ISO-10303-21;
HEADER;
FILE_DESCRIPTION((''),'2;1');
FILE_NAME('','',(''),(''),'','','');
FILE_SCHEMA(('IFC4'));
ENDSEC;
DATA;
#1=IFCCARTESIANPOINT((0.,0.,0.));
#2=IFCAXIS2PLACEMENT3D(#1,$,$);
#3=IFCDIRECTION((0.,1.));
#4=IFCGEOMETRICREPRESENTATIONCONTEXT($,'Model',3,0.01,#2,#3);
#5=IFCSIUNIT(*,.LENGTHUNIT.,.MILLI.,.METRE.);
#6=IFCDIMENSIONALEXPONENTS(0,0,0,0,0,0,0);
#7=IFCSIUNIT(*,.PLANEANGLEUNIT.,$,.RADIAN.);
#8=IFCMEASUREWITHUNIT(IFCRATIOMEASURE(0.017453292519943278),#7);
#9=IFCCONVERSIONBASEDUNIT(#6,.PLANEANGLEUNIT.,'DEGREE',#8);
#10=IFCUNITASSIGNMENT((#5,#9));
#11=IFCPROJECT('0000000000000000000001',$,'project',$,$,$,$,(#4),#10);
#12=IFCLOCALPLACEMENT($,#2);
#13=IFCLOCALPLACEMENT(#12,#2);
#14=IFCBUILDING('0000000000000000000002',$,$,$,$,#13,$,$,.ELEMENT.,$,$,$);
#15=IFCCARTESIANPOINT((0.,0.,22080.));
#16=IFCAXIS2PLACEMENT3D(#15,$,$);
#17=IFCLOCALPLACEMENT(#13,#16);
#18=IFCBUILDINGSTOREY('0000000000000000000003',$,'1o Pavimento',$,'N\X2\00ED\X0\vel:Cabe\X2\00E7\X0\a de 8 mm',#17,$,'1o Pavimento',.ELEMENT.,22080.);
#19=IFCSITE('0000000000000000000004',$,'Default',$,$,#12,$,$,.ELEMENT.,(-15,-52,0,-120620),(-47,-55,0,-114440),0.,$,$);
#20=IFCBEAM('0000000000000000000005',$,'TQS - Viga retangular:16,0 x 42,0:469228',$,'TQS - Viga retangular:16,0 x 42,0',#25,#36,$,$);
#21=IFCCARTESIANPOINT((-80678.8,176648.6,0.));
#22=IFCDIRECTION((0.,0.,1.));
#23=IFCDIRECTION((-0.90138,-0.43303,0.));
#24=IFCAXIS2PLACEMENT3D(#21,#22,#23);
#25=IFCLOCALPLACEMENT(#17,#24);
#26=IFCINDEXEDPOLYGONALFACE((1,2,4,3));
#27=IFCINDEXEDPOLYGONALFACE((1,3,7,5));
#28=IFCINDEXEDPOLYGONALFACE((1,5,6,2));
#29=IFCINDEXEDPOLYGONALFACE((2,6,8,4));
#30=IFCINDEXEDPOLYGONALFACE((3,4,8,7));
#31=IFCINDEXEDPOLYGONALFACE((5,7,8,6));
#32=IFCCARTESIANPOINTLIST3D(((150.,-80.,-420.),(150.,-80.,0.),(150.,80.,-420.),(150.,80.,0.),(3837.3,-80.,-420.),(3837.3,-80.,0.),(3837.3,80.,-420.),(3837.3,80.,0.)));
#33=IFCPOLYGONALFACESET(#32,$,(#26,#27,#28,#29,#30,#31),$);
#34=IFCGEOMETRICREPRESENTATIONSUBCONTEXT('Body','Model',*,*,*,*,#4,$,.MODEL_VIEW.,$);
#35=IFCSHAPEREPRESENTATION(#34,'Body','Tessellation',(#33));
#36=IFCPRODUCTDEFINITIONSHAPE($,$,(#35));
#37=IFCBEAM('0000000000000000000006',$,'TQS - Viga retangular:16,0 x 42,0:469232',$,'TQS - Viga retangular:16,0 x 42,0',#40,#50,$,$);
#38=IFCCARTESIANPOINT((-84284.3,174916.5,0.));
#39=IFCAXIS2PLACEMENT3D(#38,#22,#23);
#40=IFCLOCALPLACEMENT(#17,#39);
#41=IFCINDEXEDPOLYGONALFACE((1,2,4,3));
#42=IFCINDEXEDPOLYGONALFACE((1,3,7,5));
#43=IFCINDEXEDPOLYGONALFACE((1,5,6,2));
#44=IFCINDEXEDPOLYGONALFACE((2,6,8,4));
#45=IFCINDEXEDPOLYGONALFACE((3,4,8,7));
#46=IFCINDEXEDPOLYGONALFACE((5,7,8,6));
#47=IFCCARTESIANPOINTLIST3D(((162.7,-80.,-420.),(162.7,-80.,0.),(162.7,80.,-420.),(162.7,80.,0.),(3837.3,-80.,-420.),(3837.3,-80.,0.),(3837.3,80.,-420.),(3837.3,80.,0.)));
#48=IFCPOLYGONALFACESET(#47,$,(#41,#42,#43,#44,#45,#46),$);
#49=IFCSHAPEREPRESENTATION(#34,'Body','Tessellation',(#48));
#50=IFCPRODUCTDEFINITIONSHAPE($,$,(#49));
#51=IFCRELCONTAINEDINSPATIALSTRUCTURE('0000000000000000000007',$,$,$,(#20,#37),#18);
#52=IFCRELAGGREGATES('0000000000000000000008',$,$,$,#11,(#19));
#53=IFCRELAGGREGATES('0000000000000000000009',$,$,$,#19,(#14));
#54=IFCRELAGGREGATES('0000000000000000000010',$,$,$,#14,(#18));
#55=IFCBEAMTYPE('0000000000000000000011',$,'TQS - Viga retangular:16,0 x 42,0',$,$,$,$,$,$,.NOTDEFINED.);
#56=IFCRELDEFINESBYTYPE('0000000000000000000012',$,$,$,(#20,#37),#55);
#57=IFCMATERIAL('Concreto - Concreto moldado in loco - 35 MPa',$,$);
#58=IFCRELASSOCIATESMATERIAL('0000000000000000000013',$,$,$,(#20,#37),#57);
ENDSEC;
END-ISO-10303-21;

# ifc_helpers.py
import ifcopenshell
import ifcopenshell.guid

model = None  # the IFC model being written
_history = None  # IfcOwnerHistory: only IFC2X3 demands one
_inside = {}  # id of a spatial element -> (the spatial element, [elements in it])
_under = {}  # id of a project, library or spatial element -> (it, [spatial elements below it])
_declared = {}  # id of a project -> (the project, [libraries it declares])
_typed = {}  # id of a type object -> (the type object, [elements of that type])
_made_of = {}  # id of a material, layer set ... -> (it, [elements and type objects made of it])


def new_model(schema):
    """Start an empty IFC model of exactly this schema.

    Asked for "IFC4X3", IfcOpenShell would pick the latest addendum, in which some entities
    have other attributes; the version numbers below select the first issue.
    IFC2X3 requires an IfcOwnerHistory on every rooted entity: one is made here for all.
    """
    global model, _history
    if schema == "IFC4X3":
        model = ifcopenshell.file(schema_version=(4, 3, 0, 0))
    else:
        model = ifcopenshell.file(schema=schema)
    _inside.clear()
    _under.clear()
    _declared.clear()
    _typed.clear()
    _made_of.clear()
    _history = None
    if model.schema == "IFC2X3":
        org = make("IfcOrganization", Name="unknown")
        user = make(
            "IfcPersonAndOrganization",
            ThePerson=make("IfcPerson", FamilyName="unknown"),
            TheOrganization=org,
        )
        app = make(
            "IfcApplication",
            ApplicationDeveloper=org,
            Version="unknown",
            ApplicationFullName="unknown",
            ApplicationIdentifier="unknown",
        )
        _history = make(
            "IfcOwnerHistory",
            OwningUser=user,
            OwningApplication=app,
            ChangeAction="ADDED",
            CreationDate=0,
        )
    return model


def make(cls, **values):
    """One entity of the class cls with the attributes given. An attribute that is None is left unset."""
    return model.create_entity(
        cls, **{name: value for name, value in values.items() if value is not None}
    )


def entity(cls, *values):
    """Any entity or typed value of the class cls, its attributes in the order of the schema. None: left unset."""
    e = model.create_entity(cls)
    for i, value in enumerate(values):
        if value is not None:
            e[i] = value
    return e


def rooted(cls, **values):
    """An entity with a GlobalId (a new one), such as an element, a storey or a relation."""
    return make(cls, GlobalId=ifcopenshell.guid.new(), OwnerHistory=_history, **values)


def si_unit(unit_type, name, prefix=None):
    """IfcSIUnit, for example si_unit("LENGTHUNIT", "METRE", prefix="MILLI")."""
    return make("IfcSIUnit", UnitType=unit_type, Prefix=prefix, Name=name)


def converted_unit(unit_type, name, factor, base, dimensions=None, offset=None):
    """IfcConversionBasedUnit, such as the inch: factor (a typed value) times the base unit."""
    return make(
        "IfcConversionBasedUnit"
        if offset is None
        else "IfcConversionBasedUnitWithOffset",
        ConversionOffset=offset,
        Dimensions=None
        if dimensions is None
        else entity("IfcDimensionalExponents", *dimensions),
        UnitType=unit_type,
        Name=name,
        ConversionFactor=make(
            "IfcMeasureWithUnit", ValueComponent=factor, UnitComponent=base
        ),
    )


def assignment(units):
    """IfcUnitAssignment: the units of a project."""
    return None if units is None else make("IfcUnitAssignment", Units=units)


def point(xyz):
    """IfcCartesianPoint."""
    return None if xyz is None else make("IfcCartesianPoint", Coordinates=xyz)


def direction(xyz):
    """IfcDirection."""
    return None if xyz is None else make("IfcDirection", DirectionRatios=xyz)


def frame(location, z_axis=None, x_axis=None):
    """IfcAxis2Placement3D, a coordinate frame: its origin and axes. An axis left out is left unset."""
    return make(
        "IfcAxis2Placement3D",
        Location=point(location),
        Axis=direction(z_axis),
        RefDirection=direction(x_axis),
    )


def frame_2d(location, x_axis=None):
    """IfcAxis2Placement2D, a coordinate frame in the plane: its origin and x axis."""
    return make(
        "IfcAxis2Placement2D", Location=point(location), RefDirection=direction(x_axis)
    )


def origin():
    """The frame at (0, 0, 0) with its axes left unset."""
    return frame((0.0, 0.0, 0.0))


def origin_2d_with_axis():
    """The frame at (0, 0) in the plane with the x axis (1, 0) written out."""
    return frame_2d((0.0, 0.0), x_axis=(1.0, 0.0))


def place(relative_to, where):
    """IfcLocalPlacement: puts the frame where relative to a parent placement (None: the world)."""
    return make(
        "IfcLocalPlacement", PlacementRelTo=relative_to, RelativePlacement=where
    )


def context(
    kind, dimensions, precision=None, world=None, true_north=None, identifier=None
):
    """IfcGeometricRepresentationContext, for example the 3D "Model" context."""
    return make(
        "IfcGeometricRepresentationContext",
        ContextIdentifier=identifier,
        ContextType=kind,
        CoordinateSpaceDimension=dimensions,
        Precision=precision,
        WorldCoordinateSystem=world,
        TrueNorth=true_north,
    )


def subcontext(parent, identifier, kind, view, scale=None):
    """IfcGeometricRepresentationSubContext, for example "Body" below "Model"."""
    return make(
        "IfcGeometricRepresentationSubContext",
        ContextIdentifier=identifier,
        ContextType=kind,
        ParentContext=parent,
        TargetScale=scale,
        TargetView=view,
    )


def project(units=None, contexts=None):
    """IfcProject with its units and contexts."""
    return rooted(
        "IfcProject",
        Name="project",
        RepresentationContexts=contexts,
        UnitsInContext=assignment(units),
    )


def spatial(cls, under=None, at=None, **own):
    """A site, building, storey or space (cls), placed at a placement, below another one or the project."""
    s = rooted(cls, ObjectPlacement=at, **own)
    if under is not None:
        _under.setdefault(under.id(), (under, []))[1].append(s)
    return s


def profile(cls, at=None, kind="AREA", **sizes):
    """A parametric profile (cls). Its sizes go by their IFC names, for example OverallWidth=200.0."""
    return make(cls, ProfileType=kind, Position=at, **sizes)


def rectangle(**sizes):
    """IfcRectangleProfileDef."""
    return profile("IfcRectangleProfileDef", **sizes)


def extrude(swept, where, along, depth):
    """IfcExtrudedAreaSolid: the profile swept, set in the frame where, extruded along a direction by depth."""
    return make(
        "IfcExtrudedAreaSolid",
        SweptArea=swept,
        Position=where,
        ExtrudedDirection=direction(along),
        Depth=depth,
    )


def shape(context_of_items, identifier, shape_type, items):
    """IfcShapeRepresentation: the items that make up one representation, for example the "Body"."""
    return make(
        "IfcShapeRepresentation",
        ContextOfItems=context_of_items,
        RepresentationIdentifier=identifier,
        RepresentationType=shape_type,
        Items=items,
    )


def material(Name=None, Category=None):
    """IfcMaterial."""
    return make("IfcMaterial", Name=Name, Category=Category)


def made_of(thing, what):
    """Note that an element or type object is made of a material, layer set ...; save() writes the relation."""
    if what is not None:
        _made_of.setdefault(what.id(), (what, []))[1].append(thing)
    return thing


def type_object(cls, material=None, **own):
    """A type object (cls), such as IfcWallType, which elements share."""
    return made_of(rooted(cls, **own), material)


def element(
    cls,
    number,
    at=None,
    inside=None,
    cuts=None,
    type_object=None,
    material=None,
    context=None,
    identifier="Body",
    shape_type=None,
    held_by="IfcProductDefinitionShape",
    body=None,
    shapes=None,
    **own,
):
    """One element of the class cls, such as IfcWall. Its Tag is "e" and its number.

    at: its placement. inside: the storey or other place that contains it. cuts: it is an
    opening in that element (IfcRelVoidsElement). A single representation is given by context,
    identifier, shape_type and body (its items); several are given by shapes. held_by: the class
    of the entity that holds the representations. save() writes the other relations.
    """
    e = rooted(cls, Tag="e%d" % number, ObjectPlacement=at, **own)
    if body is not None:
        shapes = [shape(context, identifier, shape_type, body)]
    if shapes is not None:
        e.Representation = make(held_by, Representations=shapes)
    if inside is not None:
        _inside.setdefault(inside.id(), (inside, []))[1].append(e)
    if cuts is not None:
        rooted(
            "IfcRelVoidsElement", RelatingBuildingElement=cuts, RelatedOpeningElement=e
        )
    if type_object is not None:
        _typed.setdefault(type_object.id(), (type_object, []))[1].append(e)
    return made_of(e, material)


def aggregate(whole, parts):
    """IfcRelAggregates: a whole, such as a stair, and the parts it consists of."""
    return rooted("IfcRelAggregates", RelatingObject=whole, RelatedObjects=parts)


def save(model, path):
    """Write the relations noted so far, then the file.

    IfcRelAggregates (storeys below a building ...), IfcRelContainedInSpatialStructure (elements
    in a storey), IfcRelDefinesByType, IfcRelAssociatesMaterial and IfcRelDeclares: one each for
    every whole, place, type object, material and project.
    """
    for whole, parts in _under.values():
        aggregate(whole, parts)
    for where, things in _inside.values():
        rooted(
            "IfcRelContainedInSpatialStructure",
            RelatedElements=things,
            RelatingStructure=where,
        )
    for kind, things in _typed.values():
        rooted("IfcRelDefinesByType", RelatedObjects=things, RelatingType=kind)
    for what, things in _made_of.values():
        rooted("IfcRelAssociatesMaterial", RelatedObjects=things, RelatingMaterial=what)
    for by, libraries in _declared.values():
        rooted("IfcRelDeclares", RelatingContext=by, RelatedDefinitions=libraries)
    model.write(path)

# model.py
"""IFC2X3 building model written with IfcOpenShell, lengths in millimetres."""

from ifc_helpers import new_model, entity, si_unit, converted_unit, direction, frame, frame_2d, origin, origin_2d_with_axis, place, context, subcontext, project, spatial, rectangle, extrude, material, type_object, element, save


model = new_model("IFC2X3")

# Units and contexts
model_context = context("Model", 3, precision=0.01, world=origin(), true_north=direction((0.0, 1.0)))
body_context = subcontext(model_context, "Body", "Model", "MODEL_VIEW")
ifc_project = project(units=[si_unit("LENGTHUNIT", "METRE", prefix="MILLI"), converted_unit("PLANEANGLEUNIT", "DEGREE", entity("IfcRatioMeasure", 0.017453292519943278), si_unit("PLANEANGLEUNIT", "RADIAN"), dimensions=[0, 0, 0, 0, 0, 0, 0])], contexts=[model_context])

# Site, building, storey
site_placement = place(None, origin())
site = spatial("IfcSite", under=ifc_project, at=site_placement, Name="Default", CompositionType="ELEMENT", RefLatitude=(-15, -52, 0, -120620), RefLongitude=(-47, -55, 0, -114440), RefElevation=0.0)
building_placement = place(site_placement, origin())
building = spatial("IfcBuilding", under=site, at=building_placement, CompositionType="ELEMENT")
storey_placement = place(building_placement, frame((0.0, 0.0, 22080.0)))
storey = spatial("IfcBuildingStorey", under=building, at=storey_placement, Name="1o Pavimento", ObjectType="Nível:Cabeça de 8 mm", LongName="1o Pavimento", CompositionType="ELEMENT", Elevation=22080.0)

# Beams
ifc_material_1 = material(Name="Concreto - Concreto moldado in loco - 35 MPa")
beam_type_1 = type_object("IfcBeamType", Name="TQS - Viga retangular:16,0 x 42,0", PredefinedType="NOTDEFINED")
beam_1_placement = place(storey_placement, frame((-80678.8, 176648.6, 0.0), z_axis=(0.0, 0.0, 1.0), x_axis=(-0.90138, -0.43303, 0.0)))
element("IfcBeam", 1, at=beam_1_placement, inside=storey, type_object=beam_type_1, material=ifc_material_1, Name="TQS - Viga retangular:16,0 x 42,0:469228", ObjectType="TQS - Viga retangular:16,0 x 42,0", context=body_context, shape_type="SweptSolid", body=[
    extrude(rectangle(XDim=420.0, YDim=160.0, at=frame_2d((0.0, 0.0), x_axis=(1.0, 0.0))), frame((150.0, 0.0, -210.0), z_axis=(1.0, 0.0, 0.0), x_axis=(0.0, 0.0, -1.0)), (0.0, 0.0, 1.0), 3687.3),
])
beam_2_placement = place(storey_placement, frame((-84284.3, 174916.5, 0.0), z_axis=(0.0, 0.0, 1.0), x_axis=(-0.90138, -0.43303, 0.0)))
element("IfcBeam", 2, at=beam_2_placement, inside=storey, type_object=beam_type_1, material=ifc_material_1, Name="TQS - Viga retangular:16,0 x 42,0:469232", ObjectType="TQS - Viga retangular:16,0 x 42,0", context=body_context, shape_type="SweptSolid", body=[
    extrude(rectangle(XDim=420.0, YDim=160.0, at=origin_2d_with_axis()), frame((162.7, 0.0, -210.0), z_axis=(1.0, 0.0, 0.0), x_axis=(0.0, 0.0, -1.0)), (0.0, 0.0, 1.0), 3674.6),
])

save(model, "model.ifc")
